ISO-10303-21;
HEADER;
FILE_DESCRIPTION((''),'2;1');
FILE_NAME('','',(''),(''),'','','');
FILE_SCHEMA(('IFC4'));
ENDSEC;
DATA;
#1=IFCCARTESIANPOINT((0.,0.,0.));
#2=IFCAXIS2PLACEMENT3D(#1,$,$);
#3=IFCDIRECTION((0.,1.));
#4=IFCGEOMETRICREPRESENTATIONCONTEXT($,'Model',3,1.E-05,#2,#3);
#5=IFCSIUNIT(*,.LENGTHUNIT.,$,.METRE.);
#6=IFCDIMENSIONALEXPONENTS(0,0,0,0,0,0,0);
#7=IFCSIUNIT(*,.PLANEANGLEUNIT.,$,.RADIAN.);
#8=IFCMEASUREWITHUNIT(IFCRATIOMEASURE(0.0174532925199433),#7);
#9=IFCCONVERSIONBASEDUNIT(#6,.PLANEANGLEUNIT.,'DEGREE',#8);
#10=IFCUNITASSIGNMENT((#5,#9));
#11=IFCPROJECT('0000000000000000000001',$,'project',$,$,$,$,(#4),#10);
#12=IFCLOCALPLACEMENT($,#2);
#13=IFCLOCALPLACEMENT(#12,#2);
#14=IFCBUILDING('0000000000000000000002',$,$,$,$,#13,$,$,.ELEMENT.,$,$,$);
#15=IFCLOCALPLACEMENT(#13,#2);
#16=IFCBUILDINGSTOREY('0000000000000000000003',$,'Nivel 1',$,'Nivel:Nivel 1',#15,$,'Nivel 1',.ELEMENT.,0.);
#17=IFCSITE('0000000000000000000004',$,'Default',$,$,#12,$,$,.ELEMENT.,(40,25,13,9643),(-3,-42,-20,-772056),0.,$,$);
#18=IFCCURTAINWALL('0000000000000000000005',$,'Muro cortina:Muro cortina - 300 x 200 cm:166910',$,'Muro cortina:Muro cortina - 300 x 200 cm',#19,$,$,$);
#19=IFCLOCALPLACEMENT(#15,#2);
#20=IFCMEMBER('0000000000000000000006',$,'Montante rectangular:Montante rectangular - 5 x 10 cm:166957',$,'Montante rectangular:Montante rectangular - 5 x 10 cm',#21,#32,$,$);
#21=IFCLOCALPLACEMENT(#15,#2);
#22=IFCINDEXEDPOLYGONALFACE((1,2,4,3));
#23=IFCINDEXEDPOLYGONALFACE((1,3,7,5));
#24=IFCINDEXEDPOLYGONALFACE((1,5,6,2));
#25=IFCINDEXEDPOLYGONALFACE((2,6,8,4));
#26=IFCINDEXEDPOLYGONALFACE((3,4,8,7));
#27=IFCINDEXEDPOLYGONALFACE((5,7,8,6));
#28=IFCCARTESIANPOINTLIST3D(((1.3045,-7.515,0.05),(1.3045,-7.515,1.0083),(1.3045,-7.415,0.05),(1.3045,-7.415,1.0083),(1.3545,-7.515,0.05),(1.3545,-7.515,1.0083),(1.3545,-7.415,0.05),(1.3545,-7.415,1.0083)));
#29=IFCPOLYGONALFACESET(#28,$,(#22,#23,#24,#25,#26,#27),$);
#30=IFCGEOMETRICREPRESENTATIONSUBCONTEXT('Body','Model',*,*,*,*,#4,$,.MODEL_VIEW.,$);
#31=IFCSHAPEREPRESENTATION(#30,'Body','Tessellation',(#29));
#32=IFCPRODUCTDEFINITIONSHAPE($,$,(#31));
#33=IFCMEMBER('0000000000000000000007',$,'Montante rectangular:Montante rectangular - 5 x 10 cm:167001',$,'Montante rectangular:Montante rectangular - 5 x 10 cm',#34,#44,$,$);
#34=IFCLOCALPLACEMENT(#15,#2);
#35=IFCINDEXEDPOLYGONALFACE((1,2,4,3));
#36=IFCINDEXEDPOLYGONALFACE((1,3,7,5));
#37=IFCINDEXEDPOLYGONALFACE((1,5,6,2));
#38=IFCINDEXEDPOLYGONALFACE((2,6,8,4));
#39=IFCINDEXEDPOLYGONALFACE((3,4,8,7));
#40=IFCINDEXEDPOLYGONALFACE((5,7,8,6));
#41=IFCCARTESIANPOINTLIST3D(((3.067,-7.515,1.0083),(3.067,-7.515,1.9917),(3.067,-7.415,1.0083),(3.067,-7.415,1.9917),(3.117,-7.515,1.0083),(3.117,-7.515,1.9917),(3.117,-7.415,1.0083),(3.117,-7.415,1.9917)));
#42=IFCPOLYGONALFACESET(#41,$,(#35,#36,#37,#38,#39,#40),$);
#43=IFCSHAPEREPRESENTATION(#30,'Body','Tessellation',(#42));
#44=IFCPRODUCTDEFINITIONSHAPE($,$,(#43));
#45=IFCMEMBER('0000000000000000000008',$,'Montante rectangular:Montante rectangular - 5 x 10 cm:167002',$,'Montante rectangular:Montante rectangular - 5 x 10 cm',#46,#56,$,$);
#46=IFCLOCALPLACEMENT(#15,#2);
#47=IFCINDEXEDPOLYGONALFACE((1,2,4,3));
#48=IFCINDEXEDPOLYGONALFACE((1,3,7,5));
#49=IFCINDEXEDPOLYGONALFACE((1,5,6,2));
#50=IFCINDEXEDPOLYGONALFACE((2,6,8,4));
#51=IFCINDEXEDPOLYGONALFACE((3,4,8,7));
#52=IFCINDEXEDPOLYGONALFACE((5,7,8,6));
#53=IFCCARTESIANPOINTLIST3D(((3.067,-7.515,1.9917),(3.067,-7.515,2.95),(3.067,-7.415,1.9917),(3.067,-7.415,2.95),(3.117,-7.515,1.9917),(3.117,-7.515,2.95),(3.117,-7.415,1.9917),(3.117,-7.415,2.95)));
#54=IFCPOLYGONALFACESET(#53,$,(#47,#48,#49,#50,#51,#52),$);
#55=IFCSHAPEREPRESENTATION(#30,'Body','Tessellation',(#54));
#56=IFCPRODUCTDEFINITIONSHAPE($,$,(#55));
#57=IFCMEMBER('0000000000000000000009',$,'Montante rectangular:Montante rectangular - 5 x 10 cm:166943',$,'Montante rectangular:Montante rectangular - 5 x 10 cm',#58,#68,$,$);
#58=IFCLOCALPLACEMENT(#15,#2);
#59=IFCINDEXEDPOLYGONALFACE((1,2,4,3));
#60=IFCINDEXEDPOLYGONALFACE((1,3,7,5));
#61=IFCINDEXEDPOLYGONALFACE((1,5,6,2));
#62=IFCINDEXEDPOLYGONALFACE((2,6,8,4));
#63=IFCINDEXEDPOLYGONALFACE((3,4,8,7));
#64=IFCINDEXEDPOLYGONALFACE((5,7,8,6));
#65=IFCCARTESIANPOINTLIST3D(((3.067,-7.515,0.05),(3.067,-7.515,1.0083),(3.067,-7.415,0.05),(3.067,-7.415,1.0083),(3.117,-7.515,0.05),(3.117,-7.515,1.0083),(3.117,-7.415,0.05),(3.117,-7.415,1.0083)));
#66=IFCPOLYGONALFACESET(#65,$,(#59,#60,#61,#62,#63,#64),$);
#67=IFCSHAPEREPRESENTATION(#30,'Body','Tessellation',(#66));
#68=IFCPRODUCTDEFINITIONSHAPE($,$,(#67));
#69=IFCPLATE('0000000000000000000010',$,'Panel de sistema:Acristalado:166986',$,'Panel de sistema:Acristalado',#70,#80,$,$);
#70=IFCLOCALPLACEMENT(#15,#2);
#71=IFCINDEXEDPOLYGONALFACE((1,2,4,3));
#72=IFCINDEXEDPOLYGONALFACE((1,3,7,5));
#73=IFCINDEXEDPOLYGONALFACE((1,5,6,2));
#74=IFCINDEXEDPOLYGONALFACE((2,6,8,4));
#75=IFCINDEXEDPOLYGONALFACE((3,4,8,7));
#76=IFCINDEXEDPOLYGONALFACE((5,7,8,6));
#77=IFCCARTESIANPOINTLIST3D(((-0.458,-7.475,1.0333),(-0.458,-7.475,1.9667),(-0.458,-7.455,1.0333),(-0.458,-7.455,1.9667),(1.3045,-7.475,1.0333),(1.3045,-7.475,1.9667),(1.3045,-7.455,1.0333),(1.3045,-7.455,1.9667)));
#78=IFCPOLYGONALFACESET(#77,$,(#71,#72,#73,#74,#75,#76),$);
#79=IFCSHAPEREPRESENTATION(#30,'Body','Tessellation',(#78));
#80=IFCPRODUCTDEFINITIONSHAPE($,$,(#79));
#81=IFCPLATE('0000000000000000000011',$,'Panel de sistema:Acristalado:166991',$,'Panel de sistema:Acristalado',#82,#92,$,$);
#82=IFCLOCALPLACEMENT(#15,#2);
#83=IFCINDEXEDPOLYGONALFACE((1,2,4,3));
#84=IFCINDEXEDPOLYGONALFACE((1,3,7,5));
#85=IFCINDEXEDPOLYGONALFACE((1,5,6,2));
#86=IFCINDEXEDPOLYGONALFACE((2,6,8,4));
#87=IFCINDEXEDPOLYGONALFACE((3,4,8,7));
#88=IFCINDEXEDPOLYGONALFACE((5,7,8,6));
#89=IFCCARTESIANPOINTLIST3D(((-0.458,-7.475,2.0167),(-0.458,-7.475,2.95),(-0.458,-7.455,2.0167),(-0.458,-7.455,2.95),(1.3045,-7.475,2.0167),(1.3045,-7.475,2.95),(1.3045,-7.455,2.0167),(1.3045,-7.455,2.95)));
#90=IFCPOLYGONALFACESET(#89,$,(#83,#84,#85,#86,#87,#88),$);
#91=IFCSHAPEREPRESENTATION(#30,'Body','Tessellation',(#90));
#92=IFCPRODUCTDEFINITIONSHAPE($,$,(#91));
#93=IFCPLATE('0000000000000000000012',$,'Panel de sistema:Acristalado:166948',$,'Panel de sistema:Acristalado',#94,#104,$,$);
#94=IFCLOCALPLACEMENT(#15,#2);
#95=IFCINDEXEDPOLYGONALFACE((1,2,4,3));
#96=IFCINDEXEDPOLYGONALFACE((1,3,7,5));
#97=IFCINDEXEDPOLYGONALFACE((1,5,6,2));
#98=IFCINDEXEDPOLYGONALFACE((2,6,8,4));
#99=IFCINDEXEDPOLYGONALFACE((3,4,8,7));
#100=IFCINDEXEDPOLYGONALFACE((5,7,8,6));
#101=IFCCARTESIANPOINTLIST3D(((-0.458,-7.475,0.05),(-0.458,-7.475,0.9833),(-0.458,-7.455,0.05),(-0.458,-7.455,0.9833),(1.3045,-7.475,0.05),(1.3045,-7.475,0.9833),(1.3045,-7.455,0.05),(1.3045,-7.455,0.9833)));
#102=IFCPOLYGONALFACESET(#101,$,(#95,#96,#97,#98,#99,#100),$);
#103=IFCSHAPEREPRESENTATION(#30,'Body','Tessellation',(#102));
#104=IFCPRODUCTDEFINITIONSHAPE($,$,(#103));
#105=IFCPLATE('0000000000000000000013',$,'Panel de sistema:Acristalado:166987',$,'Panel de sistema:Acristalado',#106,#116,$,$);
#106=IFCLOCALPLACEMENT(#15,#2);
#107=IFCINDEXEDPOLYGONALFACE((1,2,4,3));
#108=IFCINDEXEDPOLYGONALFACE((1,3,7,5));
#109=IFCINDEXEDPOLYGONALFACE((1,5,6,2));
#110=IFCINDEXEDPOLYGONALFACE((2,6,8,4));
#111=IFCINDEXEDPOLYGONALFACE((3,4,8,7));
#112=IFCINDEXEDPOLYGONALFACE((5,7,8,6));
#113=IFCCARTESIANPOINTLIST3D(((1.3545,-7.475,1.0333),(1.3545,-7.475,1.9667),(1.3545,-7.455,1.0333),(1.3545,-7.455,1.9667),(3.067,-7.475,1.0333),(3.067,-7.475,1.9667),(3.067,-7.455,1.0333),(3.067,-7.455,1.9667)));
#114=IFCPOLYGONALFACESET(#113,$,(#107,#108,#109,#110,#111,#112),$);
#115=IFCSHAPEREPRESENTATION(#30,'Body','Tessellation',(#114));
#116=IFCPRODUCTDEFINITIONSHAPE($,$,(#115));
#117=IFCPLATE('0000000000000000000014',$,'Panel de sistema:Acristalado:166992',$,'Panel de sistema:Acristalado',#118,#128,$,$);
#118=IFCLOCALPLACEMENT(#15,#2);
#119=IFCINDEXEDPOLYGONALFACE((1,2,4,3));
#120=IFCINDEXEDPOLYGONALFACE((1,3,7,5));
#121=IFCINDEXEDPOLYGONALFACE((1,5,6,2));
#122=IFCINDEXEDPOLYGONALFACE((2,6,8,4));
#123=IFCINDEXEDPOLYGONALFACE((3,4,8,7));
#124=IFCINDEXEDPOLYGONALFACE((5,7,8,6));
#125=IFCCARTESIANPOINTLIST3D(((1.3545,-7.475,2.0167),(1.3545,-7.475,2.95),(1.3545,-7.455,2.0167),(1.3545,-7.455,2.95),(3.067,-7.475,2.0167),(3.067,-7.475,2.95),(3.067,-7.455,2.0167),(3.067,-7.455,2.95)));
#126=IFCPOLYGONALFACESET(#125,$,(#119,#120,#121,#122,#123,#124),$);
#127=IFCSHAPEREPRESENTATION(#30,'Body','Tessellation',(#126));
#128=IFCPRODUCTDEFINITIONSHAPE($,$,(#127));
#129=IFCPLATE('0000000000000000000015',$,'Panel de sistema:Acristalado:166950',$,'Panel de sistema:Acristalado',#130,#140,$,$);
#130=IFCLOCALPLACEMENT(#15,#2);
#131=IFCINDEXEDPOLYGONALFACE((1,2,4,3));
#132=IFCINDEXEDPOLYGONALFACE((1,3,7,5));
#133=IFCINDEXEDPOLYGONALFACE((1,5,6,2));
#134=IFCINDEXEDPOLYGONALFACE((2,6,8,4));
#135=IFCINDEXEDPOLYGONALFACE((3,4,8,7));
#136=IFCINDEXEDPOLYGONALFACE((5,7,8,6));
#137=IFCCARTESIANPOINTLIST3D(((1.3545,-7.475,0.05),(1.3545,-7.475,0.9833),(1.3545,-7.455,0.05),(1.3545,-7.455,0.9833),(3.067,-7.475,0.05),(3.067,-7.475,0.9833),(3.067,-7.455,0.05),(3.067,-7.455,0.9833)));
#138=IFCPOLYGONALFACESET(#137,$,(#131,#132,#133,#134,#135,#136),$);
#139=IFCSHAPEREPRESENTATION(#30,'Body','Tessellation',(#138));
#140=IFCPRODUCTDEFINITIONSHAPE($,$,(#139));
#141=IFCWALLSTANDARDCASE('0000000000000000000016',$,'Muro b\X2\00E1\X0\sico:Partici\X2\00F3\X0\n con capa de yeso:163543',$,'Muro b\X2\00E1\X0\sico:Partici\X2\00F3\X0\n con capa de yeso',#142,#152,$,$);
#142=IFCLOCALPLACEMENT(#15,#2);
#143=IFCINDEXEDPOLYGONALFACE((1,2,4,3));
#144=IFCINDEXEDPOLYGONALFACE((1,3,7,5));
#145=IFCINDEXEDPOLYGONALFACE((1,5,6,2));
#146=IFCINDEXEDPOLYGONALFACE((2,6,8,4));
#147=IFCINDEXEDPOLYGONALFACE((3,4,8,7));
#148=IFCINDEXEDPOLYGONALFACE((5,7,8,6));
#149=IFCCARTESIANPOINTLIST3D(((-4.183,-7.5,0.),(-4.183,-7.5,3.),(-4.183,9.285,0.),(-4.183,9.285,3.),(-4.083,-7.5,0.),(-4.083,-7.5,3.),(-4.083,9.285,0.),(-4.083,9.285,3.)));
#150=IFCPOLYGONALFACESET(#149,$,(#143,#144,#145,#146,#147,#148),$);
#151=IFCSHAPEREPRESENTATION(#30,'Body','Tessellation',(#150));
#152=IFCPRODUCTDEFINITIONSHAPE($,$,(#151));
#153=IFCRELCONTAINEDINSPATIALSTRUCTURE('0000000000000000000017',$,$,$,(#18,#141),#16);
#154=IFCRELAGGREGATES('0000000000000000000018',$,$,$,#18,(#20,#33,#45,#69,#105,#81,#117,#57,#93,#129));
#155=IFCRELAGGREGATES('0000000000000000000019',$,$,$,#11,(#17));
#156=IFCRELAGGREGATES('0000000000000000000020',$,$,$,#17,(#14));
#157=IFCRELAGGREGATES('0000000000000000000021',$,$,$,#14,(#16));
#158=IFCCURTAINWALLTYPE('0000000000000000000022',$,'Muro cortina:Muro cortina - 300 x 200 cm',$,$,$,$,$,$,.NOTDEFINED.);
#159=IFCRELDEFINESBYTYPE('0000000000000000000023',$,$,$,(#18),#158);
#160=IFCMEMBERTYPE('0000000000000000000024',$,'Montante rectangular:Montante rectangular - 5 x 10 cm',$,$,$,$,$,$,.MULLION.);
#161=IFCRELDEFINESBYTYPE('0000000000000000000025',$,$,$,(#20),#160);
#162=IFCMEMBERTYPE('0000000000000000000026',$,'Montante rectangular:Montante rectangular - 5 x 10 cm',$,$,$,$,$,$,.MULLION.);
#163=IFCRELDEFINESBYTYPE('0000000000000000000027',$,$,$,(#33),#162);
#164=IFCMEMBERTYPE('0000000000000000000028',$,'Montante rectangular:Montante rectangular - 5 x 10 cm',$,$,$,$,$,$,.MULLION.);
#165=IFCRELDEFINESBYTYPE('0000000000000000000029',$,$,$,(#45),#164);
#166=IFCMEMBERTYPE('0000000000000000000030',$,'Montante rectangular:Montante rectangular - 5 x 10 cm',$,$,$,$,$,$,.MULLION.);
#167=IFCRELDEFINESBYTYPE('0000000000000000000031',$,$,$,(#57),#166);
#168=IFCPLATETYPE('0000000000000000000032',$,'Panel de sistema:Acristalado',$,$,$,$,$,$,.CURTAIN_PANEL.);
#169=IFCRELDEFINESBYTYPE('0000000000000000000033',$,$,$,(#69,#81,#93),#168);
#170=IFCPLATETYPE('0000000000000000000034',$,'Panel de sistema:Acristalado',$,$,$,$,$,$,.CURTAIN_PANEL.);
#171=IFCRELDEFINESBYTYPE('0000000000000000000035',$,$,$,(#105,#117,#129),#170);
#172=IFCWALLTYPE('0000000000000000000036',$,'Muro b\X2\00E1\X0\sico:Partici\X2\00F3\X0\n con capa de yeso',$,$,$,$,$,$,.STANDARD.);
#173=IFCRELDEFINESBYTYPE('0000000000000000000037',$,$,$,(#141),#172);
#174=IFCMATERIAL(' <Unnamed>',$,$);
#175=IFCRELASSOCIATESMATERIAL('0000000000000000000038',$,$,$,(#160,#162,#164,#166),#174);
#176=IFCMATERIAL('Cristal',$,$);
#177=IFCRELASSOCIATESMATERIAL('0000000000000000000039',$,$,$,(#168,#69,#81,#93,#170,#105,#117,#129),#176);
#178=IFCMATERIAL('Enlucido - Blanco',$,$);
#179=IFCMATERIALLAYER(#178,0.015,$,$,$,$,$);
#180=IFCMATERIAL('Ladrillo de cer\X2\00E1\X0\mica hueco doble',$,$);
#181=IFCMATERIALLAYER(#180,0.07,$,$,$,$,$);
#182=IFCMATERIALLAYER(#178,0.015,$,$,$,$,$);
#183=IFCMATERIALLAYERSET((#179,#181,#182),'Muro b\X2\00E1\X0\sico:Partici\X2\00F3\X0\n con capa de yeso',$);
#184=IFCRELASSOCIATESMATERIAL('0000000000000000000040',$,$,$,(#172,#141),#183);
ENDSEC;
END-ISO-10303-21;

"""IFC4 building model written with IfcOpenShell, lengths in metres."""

from ifc_helpers import new_model, entity, si_unit, converted_unit, direction, frame, frame_2d, origin, origin_2d_with_axis, place, context, subcontext, project, spatial, rectangle, extrude, source, transform, mapped, material, layer, layer_set, layer_usage, type_object, type_shapes, element, aggregate, save


model = new_model("IFC4")

# Units and contexts
model_context = context("Model", 3, precision=1e-05, world=origin(), true_north=direction((0.0, 1.0)))
body_context = subcontext(model_context, "Body", "Model", "MODEL_VIEW")
ifc_project = project(units=[si_unit("LENGTHUNIT", "METRE"), converted_unit("PLANEANGLEUNIT", "DEGREE", entity("IfcRatioMeasure", 0.0174532925199433), si_unit("PLANEANGLEUNIT", "RADIAN"), dimensions=[0, 0, 0, 0, 0, 0, 0])], contexts=[model_context])

# Site, building, storey
site_placement = place(None, origin())
site = spatial("IfcSite", under=ifc_project, at=site_placement, Name="Default", CompositionType="ELEMENT", RefLatitude=(40, 25, 13, 9643), RefLongitude=(-3, -42, -20, -772056), RefElevation=0.0)
building_placement = place(site_placement, origin())
building = spatial("IfcBuilding", under=site, at=building_placement, CompositionType="ELEMENT")
storey_placement = place(building_placement, origin())
storey = spatial("IfcBuildingStorey", under=building, at=storey_placement, Name="Nivel 1", ObjectType="Nivel:Nivel 1", LongName="Nivel 1", CompositionType="ELEMENT", Elevation=0.0)

# Curtain wall, members, plates
curtain_wall_type = type_object("IfcCurtainWallType", Name="Muro cortina:Muro cortina - 300 x 200 cm", PredefinedType="NOTDEFINED")
curtain_wall_placement = place(storey_placement, origin())
curtain_wall = element("IfcCurtainWall", 1, at=curtain_wall_placement, inside=storey, type_object=curtain_wall_type, Name="Muro cortina:Muro cortina - 300 x 200 cm:166910", ObjectType="Muro cortina:Muro cortina - 300 x 200 cm")
ifc_material_1 = material(Name=" <Unnamed>")
member_type_1 = type_object("IfcMemberType", Name="Montante rectangular:Montante rectangular - 5 x 10 cm", PredefinedType="MULLION", material=ifc_material_1)
shared_shape_1 = source(origin(), body_context, "Body", "SweptSolid", [
    extrude(rectangle(XDim=0.1, YDim=0.05, at=origin_2d_with_axis()), frame((0.0, 0.0, -0.9583), z_axis=(0.0, 0.0, 1.0), x_axis=(0.0, -1.0, 0.0)), (0.0, 0.0, 1.0), 0.9583),
])
type_shapes(member_type_1, [shared_shape_1])
member_1_placement = place(storey_placement, frame((1.3295, -7.465, 0.05), z_axis=(0.0, 0.0, -1.0), x_axis=(1.0, 0.0, 0.0)))
member_1 = element("IfcMember", 2, at=member_1_placement, type_object=member_type_1, Name="Montante rectangular:Montante rectangular - 5 x 10 cm:166957", ObjectType="Montante rectangular:Montante rectangular - 5 x 10 cm", context=body_context, shape_type="MappedRepresentation", body=[
    mapped(shared_shape_1, transform((0.0, 0.0, 0.0), scale=1.0)),
])
member_type_2 = type_object("IfcMemberType", Name="Montante rectangular:Montante rectangular - 5 x 10 cm", PredefinedType="MULLION", material=ifc_material_1)
shared_shape_2 = source(origin(), body_context, "Body", "SweptSolid", [
    extrude(rectangle(XDim=0.1, YDim=0.05, at=origin_2d_with_axis()), frame((-0.025, 0.0, -0.9833), z_axis=(0.0, 0.0, 1.0), x_axis=(0.0, -1.0, 0.0)), (0.0, 0.0, 1.0), 0.9833),
])
type_shapes(member_type_2, [shared_shape_2])
member_2_placement = place(storey_placement, frame((3.117, -7.465, 1.0083), z_axis=(0.0, 0.0, -1.0), x_axis=(1.0, 0.0, 0.0)))
member_2 = element("IfcMember", 3, at=member_2_placement, type_object=member_type_2, Name="Montante rectangular:Montante rectangular - 5 x 10 cm:167001", ObjectType="Montante rectangular:Montante rectangular - 5 x 10 cm", context=body_context, shape_type="MappedRepresentation", body=[
    mapped(shared_shape_2, transform((0.0, 0.0, 0.0), scale=1.0)),
])
member_type_3 = type_object("IfcMemberType", Name="Montante rectangular:Montante rectangular - 5 x 10 cm", PredefinedType="MULLION", material=ifc_material_1)
shared_shape_3 = source(origin(), body_context, "Body", "SweptSolid", [
    extrude(rectangle(XDim=0.1, YDim=0.05, at=origin_2d_with_axis()), frame((-0.025, 0.0, -0.9583), z_axis=(0.0, 0.0, 1.0), x_axis=(0.0, -1.0, 0.0)), (0.0, 0.0, 1.0), 0.9583),
])
type_shapes(member_type_3, [shared_shape_3])
member_3_placement = place(storey_placement, frame((3.117, -7.465, 1.9917), z_axis=(0.0, 0.0, -1.0), x_axis=(1.0, 0.0, 0.0)))
member_3 = element("IfcMember", 4, at=member_3_placement, type_object=member_type_3, Name="Montante rectangular:Montante rectangular - 5 x 10 cm:167002", ObjectType="Montante rectangular:Montante rectangular - 5 x 10 cm", context=body_context, shape_type="MappedRepresentation", body=[
    mapped(shared_shape_3, transform((0.0, 0.0, 0.0), scale=1.0)),
])
member_type_4 = type_object("IfcMemberType", Name="Montante rectangular:Montante rectangular - 5 x 10 cm", PredefinedType="MULLION", material=ifc_material_1)
shared_shape_4 = source(origin(), body_context, "Body", "SweptSolid", [
    extrude(rectangle(XDim=0.1, YDim=0.05, at=origin_2d_with_axis()), frame((-0.025, 0.0, -0.9583), z_axis=(0.0, 0.0, 1.0), x_axis=(0.0, -1.0, 0.0)), (0.0, 0.0, 1.0), 0.9583),
])
type_shapes(member_type_4, [shared_shape_4])
member_4_placement = place(storey_placement, frame((3.117, -7.465, 0.05), z_axis=(0.0, 0.0, -1.0), x_axis=(1.0, 0.0, 0.0)))
member_4 = element("IfcMember", 5, at=member_4_placement, type_object=member_type_4, Name="Montante rectangular:Montante rectangular - 5 x 10 cm:166943", ObjectType="Montante rectangular:Montante rectangular - 5 x 10 cm", context=body_context, shape_type="MappedRepresentation", body=[
    mapped(shared_shape_4, transform((0.0, 0.0, 0.0), scale=1.0)),
])
ifc_material_2 = material(Name="Cristal")
plate_type_1 = type_object("IfcPlateType", Name="Panel de sistema:Acristalado", PredefinedType="CURTAIN_PANEL", material=ifc_material_2)
shared_shape_5 = source(origin(), body_context, "Body", "SweptSolid", [
    extrude(rectangle(XDim=0.02, YDim=1.7625, at=origin_2d_with_axis()), frame((0.0, 0.0, 0.0), z_axis=(0.0, 0.0, 1.0), x_axis=(0.0, 1.0, 0.0)), (0.0, 0.0, 1.0), 0.9333),
])
type_shapes(plate_type_1, [shared_shape_5])
plate_1_placement = place(curtain_wall_placement, frame((0.4232, -7.465, 1.0333)))
plate_1 = element("IfcPlate", 6, at=plate_1_placement, type_object=plate_type_1, material=ifc_material_2, Name="Panel de sistema:Acristalado:166986", ObjectType="Panel de sistema:Acristalado", context=body_context, shape_type="MappedRepresentation", body=[
    mapped(shared_shape_5, transform((0.0, 0.0, 0.0), scale=1.0)),
])
plate_2_placement = place(curtain_wall_placement, frame((0.4232, -7.465, 2.0167)))
plate_2 = element("IfcPlate", 7, at=plate_2_placement, type_object=plate_type_1, material=ifc_material_2, Name="Panel de sistema:Acristalado:166991", ObjectType="Panel de sistema:Acristalado", context=body_context, shape_type="MappedRepresentation", body=[
    mapped(shared_shape_5, transform((0.0, 0.0, 0.0), scale=1.0)),
])
plate_3_placement = place(curtain_wall_placement, frame((0.4232, -7.465, 0.05)))
plate_3 = element("IfcPlate", 8, at=plate_3_placement, type_object=plate_type_1, material=ifc_material_2, Name="Panel de sistema:Acristalado:166948", ObjectType="Panel de sistema:Acristalado", context=body_context, shape_type="MappedRepresentation", body=[
    mapped(shared_shape_5, transform((0.0, 0.0, 0.0), scale=1.0)),
])
plate_type_2 = type_object("IfcPlateType", Name="Panel de sistema:Acristalado", PredefinedType="CURTAIN_PANEL", material=ifc_material_2)
shared_shape_6 = source(origin(), body_context, "Body", "SweptSolid", [
    extrude(rectangle(XDim=0.02, YDim=1.7125, at=origin_2d_with_axis()), frame((0.0, 0.0, 0.0), z_axis=(0.0, 0.0, 1.0), x_axis=(0.0, 1.0, 0.0)), (0.0, 0.0, 1.0), 0.9333),
])
type_shapes(plate_type_2, [shared_shape_6])
plate_4_placement = place(curtain_wall_placement, frame((2.2107, -7.465, 1.0333)))
plate_4 = element("IfcPlate", 9, at=plate_4_placement, type_object=plate_type_2, material=ifc_material_2, Name="Panel de sistema:Acristalado:166987", ObjectType="Panel de sistema:Acristalado", context=body_context, shape_type="MappedRepresentation", body=[
    mapped(shared_shape_6, transform((0.0, 0.0, 0.0), scale=1.0)),
])
plate_5_placement = place(curtain_wall_placement, frame((2.2107, -7.465, 2.0167)))
plate_5 = element("IfcPlate", 10, at=plate_5_placement, type_object=plate_type_2, material=ifc_material_2, Name="Panel de sistema:Acristalado:166992", ObjectType="Panel de sistema:Acristalado", context=body_context, shape_type="MappedRepresentation", body=[
    mapped(shared_shape_6, transform((0.0, 0.0, 0.0), scale=1.0)),
])
plate_6_placement = place(curtain_wall_placement, frame((2.2107, -7.465, 0.05)))
plate_6 = element("IfcPlate", 11, at=plate_6_placement, type_object=plate_type_2, material=ifc_material_2, Name="Panel de sistema:Acristalado:166950", ObjectType="Panel de sistema:Acristalado", context=body_context, shape_type="MappedRepresentation", body=[
    mapped(shared_shape_6, transform((0.0, 0.0, 0.0), scale=1.0)),
])
aggregate(curtain_wall, [member_1, member_2, member_3, plate_1, plate_4, plate_2, plate_5, member_4, plate_3, plate_6])

# Wall
ifc_material_3 = material(Name="Enlucido - Blanco")
ifc_layer_1 = layer(ifc_material_3, 0.015)
ifc_material_4 = material(Name="Ladrillo de cerámica hueco doble")
ifc_layer_2 = layer(ifc_material_4, 0.07)
ifc_layer_3 = layer(ifc_material_3, 0.015)
ifc_layer_set = layer_set([ifc_layer_1, ifc_layer_2, ifc_layer_3], Name="Muro básico:Partición con capa de yeso")
ifc_layer_usage = layer_usage(ifc_layer_set, "AXIS2", "NEGATIVE", 0.05)
wall_type = type_object("IfcWallType", Name="Muro básico:Partición con capa de yeso", PredefinedType="STANDARD", material=ifc_layer_set)
wall_placement = place(storey_placement, frame((-4.133, -7.5, 0.0), z_axis=(0.0, 0.0, 1.0), x_axis=(0.0, 1.0, 0.0)))
element("IfcWallStandardCase", 12, at=wall_placement, inside=storey, type_object=wall_type, material=ifc_layer_usage, Name="Muro básico:Partición con capa de yeso:163543", ObjectType="Muro básico:Partición con capa de yeso", context=body_context, shape_type="SweptSolid", body=[
    extrude(rectangle(XDim=16.785, YDim=0.1, at=frame_2d((8.3925, 0.0), x_axis=(-1.0, 0.0))), origin(), (0.0, 0.0, 1.0), 3.0),
])

save(model, "model.ifc")
